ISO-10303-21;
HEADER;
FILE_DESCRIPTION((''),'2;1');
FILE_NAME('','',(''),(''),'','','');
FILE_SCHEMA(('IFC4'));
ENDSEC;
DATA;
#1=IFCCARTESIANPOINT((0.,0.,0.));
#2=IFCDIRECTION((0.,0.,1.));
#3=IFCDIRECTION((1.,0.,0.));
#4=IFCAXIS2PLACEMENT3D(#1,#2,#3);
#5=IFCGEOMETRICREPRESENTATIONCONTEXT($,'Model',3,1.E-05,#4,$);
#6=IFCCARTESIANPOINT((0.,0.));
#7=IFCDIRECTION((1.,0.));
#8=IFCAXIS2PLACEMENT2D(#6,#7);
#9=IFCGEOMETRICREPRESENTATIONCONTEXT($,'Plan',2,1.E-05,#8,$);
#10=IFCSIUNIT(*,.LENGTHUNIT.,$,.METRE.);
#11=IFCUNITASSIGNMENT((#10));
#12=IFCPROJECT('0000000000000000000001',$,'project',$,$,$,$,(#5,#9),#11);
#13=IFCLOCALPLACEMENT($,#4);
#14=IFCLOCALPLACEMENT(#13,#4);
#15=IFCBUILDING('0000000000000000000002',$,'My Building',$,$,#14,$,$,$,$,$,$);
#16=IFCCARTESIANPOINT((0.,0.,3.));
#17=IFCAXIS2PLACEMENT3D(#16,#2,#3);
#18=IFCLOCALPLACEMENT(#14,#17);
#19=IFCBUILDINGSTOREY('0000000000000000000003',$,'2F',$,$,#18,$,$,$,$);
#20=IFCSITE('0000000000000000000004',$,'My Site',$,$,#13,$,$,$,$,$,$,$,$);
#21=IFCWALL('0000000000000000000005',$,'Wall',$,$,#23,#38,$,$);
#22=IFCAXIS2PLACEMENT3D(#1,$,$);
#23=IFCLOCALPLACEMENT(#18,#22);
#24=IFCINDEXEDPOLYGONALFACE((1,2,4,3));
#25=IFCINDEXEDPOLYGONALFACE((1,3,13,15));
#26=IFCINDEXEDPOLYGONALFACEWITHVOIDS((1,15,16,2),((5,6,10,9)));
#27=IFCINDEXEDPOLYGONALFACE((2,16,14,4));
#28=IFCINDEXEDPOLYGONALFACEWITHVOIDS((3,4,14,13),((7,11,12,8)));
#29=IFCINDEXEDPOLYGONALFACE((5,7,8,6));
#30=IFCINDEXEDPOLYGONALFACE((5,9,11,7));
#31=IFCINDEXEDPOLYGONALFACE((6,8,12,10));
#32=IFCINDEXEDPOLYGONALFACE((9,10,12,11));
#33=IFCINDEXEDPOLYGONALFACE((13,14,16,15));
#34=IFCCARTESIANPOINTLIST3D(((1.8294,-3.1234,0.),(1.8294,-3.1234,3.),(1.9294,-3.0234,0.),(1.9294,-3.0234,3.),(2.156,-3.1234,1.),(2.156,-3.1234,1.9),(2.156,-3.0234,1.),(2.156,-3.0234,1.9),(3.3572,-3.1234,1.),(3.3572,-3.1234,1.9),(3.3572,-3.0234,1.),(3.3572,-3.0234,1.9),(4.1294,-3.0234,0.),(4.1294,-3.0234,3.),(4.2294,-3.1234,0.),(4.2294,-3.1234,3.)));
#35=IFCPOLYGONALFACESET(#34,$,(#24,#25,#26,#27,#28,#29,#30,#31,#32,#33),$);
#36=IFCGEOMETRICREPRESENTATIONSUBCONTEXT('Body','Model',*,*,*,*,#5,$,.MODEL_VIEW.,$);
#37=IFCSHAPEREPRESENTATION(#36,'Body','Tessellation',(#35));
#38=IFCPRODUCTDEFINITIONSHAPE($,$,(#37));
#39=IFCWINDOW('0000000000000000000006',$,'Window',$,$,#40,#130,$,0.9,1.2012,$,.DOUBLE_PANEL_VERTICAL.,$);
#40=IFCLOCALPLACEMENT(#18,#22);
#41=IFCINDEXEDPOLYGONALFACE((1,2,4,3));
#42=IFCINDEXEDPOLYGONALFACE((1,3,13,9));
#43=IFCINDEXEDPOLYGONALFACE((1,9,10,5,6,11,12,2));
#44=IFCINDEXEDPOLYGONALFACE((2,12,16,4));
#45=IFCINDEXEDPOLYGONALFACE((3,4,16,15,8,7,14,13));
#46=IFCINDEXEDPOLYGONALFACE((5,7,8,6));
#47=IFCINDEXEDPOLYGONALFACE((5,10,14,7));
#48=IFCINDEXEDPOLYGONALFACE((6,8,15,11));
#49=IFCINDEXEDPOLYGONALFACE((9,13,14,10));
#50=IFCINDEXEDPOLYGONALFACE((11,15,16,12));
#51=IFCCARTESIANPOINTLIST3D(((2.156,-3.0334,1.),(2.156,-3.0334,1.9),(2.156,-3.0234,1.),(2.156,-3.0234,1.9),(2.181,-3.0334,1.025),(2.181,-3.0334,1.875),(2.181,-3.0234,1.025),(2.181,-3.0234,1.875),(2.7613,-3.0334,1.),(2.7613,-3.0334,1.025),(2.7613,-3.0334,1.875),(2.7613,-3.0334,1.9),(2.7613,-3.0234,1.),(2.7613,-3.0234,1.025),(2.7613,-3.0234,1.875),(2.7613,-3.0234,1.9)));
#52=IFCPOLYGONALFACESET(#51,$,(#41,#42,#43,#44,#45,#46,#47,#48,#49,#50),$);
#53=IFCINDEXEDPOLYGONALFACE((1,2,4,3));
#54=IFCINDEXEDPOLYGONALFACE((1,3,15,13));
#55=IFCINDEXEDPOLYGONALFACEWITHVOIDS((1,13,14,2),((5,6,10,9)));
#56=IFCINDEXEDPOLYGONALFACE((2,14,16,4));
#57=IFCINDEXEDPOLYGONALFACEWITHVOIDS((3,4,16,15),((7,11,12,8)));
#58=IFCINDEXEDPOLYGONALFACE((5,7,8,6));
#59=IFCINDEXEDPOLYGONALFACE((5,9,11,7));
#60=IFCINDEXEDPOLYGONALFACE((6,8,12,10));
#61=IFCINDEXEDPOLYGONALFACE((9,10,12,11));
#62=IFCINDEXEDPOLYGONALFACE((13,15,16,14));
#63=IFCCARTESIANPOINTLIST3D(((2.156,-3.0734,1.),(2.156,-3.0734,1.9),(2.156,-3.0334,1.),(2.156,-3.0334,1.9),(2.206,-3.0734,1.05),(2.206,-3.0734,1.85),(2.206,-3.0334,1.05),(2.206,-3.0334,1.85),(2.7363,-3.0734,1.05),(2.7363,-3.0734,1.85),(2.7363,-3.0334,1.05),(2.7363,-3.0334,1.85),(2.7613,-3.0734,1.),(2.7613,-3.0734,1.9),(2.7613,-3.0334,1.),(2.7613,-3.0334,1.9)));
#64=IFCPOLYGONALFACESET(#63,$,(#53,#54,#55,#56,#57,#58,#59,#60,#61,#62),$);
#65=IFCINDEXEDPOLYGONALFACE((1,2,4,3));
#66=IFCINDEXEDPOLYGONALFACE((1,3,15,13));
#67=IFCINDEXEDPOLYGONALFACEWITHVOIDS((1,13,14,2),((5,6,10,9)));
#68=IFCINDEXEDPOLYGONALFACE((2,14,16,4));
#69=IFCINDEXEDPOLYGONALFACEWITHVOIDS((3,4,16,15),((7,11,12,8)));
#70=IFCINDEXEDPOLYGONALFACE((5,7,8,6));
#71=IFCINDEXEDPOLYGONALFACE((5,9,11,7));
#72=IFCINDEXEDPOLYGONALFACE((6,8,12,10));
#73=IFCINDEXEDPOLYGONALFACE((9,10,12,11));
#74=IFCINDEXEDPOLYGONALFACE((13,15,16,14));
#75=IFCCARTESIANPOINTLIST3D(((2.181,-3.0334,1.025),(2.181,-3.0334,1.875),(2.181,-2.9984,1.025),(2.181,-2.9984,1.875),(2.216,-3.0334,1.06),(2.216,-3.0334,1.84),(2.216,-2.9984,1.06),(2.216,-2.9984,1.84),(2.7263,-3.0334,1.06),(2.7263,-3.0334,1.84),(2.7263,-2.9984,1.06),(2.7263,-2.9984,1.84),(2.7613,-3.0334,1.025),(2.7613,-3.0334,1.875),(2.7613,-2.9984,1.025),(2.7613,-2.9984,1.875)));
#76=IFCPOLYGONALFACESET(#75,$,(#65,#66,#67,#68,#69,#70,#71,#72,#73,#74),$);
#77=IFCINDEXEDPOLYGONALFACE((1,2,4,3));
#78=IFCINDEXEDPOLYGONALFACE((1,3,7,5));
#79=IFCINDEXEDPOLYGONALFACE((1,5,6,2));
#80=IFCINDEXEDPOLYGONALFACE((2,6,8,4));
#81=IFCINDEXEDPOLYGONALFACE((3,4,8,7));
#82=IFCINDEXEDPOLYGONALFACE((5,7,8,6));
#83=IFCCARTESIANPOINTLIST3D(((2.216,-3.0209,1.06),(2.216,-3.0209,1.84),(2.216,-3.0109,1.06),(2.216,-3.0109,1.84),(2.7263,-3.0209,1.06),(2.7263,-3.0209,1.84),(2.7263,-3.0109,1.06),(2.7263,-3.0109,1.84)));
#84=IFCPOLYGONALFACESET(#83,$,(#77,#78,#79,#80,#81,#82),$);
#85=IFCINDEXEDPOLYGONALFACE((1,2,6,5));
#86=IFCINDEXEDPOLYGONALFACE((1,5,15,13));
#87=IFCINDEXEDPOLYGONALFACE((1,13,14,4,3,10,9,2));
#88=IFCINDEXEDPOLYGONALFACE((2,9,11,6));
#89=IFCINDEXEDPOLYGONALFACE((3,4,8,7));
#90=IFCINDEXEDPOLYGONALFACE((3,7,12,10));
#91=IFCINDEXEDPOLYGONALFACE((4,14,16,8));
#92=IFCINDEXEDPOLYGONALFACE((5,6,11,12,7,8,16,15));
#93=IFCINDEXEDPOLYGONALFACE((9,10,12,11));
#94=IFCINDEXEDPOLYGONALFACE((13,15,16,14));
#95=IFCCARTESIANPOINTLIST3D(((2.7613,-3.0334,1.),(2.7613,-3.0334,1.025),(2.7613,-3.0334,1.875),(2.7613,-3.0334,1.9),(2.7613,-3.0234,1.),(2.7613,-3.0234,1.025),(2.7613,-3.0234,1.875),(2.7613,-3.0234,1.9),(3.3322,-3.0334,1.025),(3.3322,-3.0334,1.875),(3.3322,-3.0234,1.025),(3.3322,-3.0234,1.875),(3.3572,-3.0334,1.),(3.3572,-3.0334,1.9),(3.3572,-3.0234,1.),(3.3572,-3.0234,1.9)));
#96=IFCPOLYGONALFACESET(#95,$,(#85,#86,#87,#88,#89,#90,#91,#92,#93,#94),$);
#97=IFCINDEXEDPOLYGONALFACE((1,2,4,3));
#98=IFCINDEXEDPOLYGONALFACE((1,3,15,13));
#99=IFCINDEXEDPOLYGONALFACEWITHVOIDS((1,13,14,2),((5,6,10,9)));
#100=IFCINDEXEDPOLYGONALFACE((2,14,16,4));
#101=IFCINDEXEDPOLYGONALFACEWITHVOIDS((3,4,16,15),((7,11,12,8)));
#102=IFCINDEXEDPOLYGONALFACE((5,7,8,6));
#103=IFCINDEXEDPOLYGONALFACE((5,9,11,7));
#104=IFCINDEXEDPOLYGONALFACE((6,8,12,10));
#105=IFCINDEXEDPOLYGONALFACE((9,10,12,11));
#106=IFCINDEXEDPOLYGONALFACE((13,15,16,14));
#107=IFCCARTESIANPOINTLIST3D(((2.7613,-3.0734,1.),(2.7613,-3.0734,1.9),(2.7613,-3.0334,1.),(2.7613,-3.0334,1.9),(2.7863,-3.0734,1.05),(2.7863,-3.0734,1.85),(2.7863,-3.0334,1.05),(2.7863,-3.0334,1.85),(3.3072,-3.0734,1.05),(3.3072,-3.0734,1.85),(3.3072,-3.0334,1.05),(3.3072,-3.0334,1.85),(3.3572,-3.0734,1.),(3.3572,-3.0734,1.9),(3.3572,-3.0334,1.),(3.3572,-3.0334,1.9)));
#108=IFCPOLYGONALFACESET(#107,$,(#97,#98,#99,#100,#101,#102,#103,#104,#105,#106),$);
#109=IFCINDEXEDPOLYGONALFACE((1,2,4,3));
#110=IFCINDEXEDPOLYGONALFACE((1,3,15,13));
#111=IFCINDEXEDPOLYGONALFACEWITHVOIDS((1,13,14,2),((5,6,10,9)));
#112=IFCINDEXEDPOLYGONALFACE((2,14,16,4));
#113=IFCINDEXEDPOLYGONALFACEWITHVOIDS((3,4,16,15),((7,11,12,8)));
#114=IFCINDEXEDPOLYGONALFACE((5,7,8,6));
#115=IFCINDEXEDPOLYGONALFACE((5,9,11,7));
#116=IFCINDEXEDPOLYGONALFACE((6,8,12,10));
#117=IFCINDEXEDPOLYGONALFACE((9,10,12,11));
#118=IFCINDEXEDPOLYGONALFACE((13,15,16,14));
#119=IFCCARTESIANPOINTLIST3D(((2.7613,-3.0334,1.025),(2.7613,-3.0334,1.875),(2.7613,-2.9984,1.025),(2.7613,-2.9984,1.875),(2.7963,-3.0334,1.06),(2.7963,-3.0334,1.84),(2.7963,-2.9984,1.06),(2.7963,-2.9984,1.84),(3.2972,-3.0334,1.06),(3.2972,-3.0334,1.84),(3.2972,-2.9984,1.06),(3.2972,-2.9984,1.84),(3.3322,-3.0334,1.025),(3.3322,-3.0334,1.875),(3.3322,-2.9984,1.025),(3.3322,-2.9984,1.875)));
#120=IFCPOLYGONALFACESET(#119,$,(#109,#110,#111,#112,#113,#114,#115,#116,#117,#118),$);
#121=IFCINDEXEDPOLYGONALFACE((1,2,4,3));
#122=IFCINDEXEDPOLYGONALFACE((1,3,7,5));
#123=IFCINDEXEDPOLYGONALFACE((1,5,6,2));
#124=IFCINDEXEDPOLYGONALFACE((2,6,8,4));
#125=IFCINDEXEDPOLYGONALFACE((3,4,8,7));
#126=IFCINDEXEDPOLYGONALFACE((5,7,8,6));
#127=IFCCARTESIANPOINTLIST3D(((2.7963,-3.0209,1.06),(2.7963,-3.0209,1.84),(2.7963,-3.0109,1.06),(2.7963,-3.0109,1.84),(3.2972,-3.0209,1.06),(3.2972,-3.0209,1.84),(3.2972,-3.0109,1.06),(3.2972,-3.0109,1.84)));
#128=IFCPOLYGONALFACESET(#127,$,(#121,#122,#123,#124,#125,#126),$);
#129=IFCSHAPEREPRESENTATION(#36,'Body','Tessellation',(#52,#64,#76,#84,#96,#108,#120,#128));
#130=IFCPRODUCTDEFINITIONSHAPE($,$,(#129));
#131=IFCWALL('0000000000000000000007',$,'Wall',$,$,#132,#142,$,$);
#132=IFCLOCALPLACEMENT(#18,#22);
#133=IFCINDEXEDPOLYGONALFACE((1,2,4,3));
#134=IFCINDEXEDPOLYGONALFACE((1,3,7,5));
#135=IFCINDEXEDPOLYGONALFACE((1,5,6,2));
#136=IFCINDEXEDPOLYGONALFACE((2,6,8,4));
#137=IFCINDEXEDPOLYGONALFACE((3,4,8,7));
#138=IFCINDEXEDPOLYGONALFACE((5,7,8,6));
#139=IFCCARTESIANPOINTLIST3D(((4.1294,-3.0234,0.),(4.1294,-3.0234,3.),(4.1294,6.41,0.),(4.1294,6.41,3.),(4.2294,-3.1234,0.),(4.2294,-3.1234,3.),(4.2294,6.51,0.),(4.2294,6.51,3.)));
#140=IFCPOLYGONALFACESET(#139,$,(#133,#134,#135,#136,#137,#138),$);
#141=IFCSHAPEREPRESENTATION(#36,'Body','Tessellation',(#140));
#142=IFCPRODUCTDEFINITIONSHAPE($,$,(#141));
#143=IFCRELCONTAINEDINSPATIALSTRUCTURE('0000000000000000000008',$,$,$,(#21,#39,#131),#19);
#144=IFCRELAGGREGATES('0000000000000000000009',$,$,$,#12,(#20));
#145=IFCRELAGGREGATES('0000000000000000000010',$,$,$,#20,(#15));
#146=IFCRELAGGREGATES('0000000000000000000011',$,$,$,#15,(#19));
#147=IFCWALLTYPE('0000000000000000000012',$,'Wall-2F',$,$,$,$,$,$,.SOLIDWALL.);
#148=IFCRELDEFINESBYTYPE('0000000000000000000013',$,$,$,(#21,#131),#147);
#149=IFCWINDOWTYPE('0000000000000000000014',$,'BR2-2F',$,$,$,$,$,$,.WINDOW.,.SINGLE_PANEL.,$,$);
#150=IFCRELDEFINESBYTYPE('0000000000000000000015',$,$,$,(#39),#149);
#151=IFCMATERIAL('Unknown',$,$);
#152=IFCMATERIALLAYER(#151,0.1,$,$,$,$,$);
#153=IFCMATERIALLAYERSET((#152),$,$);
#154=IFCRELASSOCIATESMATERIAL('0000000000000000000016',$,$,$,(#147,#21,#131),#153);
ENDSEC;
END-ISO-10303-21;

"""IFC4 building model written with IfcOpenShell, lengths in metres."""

from ifc_helpers import new_model, entity, si_unit, frame, origin_with_axes, origin_2d_with_axis, place, context, subcontext, project, spatial, line, indexed_curve, outline, extrude, shape, source, transform, mapped, material, layer, layer_set, layer_usage, type_object, type_shapes, element, fill, save


model = new_model("IFC4")

# Units and contexts
model_context = context("Model", 3, precision=1e-05, world=origin_with_axes())
plan_context = context("Plan", 2, precision=1e-05, world=origin_2d_with_axis())
body_context_1 = subcontext(model_context, "Body", "Model", "MODEL_VIEW")
body_context_2 = subcontext(plan_context, "Body", "Plan", "PLAN_VIEW")
ifc_project = project(units=[si_unit("LENGTHUNIT", "METRE")], contexts=[model_context, plan_context])

# Site, building, storey
site_placement = place(None, origin_with_axes())
site = spatial("IfcSite", under=ifc_project, at=site_placement, Name="My Site")
building_placement = place(site_placement, origin_with_axes())
building = spatial("IfcBuilding", under=site, at=building_placement, Name="My Building")
storey_placement = place(building_placement, frame((0.0, 0.0, 3.0), z_axis=(0.0, 0.0, 1.0), x_axis=(1.0, 0.0, 0.0)))
storey = spatial("IfcBuildingStorey", under=building, at=storey_placement, Name="2F")

# Shared definitions
ifc_material = material(Name="Unknown")
ifc_layer = layer(ifc_material, 0.1)
ifc_layer_set = layer_set([ifc_layer])
wall_type = type_object("IfcWallType", Name="Wall-2F", PredefinedType="SOLIDWALL", material=ifc_layer_set)

# Wall, opening, window
ifc_layer_usage_1 = layer_usage(ifc_layer_set, "AXIS2", "POSITIVE", 0.0)
wall_1_placement = place(storey_placement, frame((1.8294, -3.1234, 0.0), z_axis=(0.0, 0.0, 1.0), x_axis=(1.0, 0.0, 0.0)))
wall_1 = element("IfcWall", 1, at=wall_1_placement, inside=storey, type_object=wall_type, material=ifc_layer_usage_1, Name="Wall", context=body_context_1, shape_type="SweptSolid", body=[
    extrude(outline(indexed_curve([(0.0, 0.0), (0.1, 0.1), (2.3, 0.1), (2.4, 0.0)], segments=[line(1, 2, 3, 4, 1)])), origin_with_axes(), (0.0, 0.0, 1.0), 3.0),
])
shared_shape_1 = source(origin_with_axes(), body_context_1, "Body", "SweptSolid", [
    extrude(outline(indexed_curve([(0.0, 0.0), (1.2012, 0.0), (1.2012, 0.9), (0.0, 0.9)], segments=[line(1, 2, 3, 4, 1)])), frame((0.0, -0.6, 0.0), z_axis=(0.0, -1.0, 0.0), x_axis=(1.0, 0.0, 0.0)), (0.0, 0.0, -1.0), 1.2),
])
opening_1_placement = place(wall_1_placement, frame((0.3266, 0.0, 1.0), z_axis=(0.0, 0.0, 1.0), x_axis=(1.0, 0.0, 0.0)))
opening_1 = element("IfcOpeningElement", 2, at=opening_1_placement, cuts=wall_1, PredefinedType="OPENING", context=body_context_1, shape_type="MappedRepresentation", body=[
    mapped(shared_shape_1, transform((0.0, 0.0, 0.0), x_axis=(1.0, 0.0, 0.0), y_axis=(0.0, 1.0, 0.0), z_axis=(0.0, 0.0, 1.0), scale=1.0)),
])
window_type_1 = type_object("IfcWindowType", Name="BR2-2F", PartitioningType="SINGLE_PANEL", PredefinedType="WINDOW")
shared_shape_2 = source(origin_with_axes(), body_context_1, "Body", "SweptSolid", [
    extrude(outline(indexed_curve([(0.6053, 0.0), (0.0, 0.0), (0.0, 0.9), (0.6053, 0.9), (0.6053, 0.875), (0.025, 0.875), (0.025, 0.025), (0.6053, 0.025)], segments=[line(1, 2, 3, 4, 5, 6, 7, 8, 1)])), frame((0.0, 0.09, 0.0), z_axis=(0.0, -1.0, 0.0), x_axis=(1.0, 0.0, 0.0)), (0.0, 0.0, -1.0), 0.01),
    extrude(outline(indexed_curve([(0.0, 0.0), (0.6053, 0.0), (0.6053, 0.9), (0.0, 0.9)], segments=[line(1, 2, 3, 4, 1)]), holes=[indexed_curve([(0.05, 0.05), (0.5803, 0.05), (0.5803, 0.85), (0.05, 0.85)], segments=[line(1, 2, 3, 4, 1)])]), frame((0.0, 0.05, 0.0), z_axis=(0.0, -1.0, 0.0), x_axis=(1.0, 0.0, 0.0)), (0.0, 0.0, -1.0), 0.04),
    extrude(outline(indexed_curve([(0.0, 0.0), (0.5803, 0.0), (0.5803, 0.85), (0.0, 0.85)], segments=[line(1, 2, 3, 4, 1)]), holes=[indexed_curve([(0.035, 0.035), (0.5453, 0.035), (0.5453, 0.815), (0.035, 0.815)], segments=[line(1, 2, 3, 4, 1)])]), frame((0.025, 0.09, 0.025), z_axis=(0.0, -1.0, 0.0), x_axis=(1.0, 0.0, 0.0)), (0.0, 0.0, -1.0), 0.035),
    extrude(outline(indexed_curve([(0.035, 0.035), (0.5453, 0.035), (0.5453, 0.815), (0.035, 0.815)], segments=[line(1, 2, 3, 4, 1)])), frame((0.025, 0.1025, 0.025), z_axis=(0.0, -1.0, 0.0), x_axis=(1.0, 0.0, 0.0)), (0.0, 0.0, -1.0), 0.01),
    extrude(outline(indexed_curve([(0.0, 0.9), (0.5958, 0.9), (0.5958, 0.0), (0.0, 0.0), (0.0, 0.025), (0.5708, 0.025), (0.5708, 0.875), (0.0, 0.875)], segments=[line(1, 2, 3, 4, 5, 6, 7, 8, 1)])), frame((0.6053, 0.09, 0.0), z_axis=(0.0, -1.0, 0.0), x_axis=(1.0, 0.0, 0.0)), (0.0, 0.0, -1.0), 0.01),
    extrude(outline(indexed_curve([(0.0, 0.0), (0.5958, 0.0), (0.5958, 0.9), (0.0, 0.9)], segments=[line(1, 2, 3, 4, 1)]), holes=[indexed_curve([(0.025, 0.05), (0.5458, 0.05), (0.5458, 0.85), (0.025, 0.85)], segments=[line(1, 2, 3, 4, 1)])]), frame((0.6053, 0.05, 0.0), z_axis=(0.0, -1.0, 0.0), x_axis=(1.0, 0.0, 0.0)), (0.0, 0.0, -1.0), 0.04),
    extrude(outline(indexed_curve([(0.0, 0.0), (0.5708, 0.0), (0.5708, 0.85), (0.0, 0.85)], segments=[line(1, 2, 3, 4, 1)]), holes=[indexed_curve([(0.035, 0.035), (0.5358, 0.035), (0.5358, 0.815), (0.035, 0.815)], segments=[line(1, 2, 3, 4, 1)])]), frame((0.6053, 0.09, 0.025), z_axis=(0.0, -1.0, 0.0), x_axis=(1.0, 0.0, 0.0)), (0.0, 0.0, -1.0), 0.035),
    extrude(outline(indexed_curve([(0.035, 0.035), (0.5358, 0.035), (0.5358, 0.815), (0.035, 0.815)], segments=[line(1, 2, 3, 4, 1)])), frame((0.6053, 0.1025, 0.025), z_axis=(0.0, -1.0, 0.0), x_axis=(1.0, 0.0, 0.0)), (0.0, 0.0, -1.0), 0.01),
])
shared_shape_3 = source(origin_with_axes(), body_context_2, "Body", "Curve2D", [
    entity("IfcIndexedPolyCurve", entity("IfcCartesianPointList2D", [[0.05, 0.05], [0.5803, 0.05]])),
    entity("IfcIndexedPolyCurve", entity("IfcCartesianPointList2D", [[0.0, 0.1], [0.025, 0.1], [0.025, 0.09], [0.05, 0.09], [0.05, 0.05], [0.0, 0.05]]), [entity("IfcLineIndex", [1, 2, 3, 4, 5, 6, 1])]),
    entity("IfcIndexedPolyCurve", entity("IfcCartesianPointList2D", [[0.6053, 0.1], [0.6053, 0.1], [0.6053, 0.09], [0.5803, 0.09], [0.5803, 0.05], [0.6053, 0.05]])),
    entity("IfcIndexedPolyCurve", entity("IfcCartesianPointList2D", [[0.025, 0.09], [0.06, 0.09], [0.06, 0.125], [0.025, 0.125]]), [entity("IfcLineIndex", [1, 2, 3, 4, 1])]),
    entity("IfcIndexedPolyCurve", entity("IfcCartesianPointList2D", [[0.6053, 0.09], [0.5703, 0.09], [0.5703, 0.125], [0.6053, 0.125]]), [entity("IfcLineIndex", [1, 2, 3, 4, 1])]),
    entity("IfcIndexedPolyCurve", entity("IfcCartesianPointList2D", [[0.06, 0.09], [0.5703, 0.09]])),
    entity("IfcIndexedPolyCurve", entity("IfcCartesianPointList2D", [[0.06, 0.125], [0.5703, 0.125]])),
    entity("IfcIndexedPolyCurve", entity("IfcCartesianPointList2D", [[0.06, 0.1075], [0.5703, 0.1075]])),
    entity("IfcIndexedPolyCurve", entity("IfcCartesianPointList2D", [[0.6303, 0.05], [1.1512, 0.05]])),
    entity("IfcIndexedPolyCurve", entity("IfcCartesianPointList2D", [[0.6053, 0.1], [0.6053, 0.1], [0.6053, 0.09], [0.6303, 0.09], [0.6303, 0.05], [0.6053, 0.05]])),
    entity("IfcIndexedPolyCurve", entity("IfcCartesianPointList2D", [[1.2012, 0.1], [1.1762, 0.1], [1.1762, 0.09], [1.1512, 0.09], [1.1512, 0.05], [1.2012, 0.05]]), [entity("IfcLineIndex", [1, 2, 3, 4, 5, 6, 1])]),
    entity("IfcIndexedPolyCurve", entity("IfcCartesianPointList2D", [[0.6053, 0.09], [0.6403, 0.09], [0.6403, 0.125], [0.6053, 0.125]]), [entity("IfcLineIndex", [1, 2, 3, 4, 1])]),
    entity("IfcIndexedPolyCurve", entity("IfcCartesianPointList2D", [[1.1762, 0.09], [1.1412, 0.09], [1.1412, 0.125], [1.1762, 0.125]]), [entity("IfcLineIndex", [1, 2, 3, 4, 1])]),
    entity("IfcIndexedPolyCurve", entity("IfcCartesianPointList2D", [[0.6403, 0.09], [1.1412, 0.09]])),
    entity("IfcIndexedPolyCurve", entity("IfcCartesianPointList2D", [[0.6403, 0.125], [1.1412, 0.125]])),
    entity("IfcIndexedPolyCurve", entity("IfcCartesianPointList2D", [[0.6403, 0.1075], [1.1412, 0.1075]])),
])
type_shapes(window_type_1, [shared_shape_2, shared_shape_3])
window_1_placement = place(opening_1_placement, origin_with_axes())
window_1 = element("IfcWindow", 3, at=window_1_placement, inside=storey, type_object=window_type_1, Name="Window", OverallHeight=0.9, OverallWidth=1.2012, PartitioningType="DOUBLE_PANEL_VERTICAL", shapes=[
    shape(body_context_1, "Body", "MappedRepresentation", [mapped(shared_shape_2, transform((0.0, 0.0, 0.0), x_axis=(1.0, 0.0, 0.0), y_axis=(0.0, 1.0, 0.0), z_axis=(0.0, 0.0, 1.0), scale=1.0))]),
    shape(body_context_2, "Body", "MappedRepresentation", [mapped(shared_shape_3, transform((0.0, 0.0, 0.0), x_axis=(1.0, 0.0, 0.0), y_axis=(0.0, 1.0, 0.0), z_axis=(0.0, 0.0, 1.0), scale=1.0))]),
])
fill(opening_1, window_1)

# Wall
ifc_layer_usage_2 = layer_usage(ifc_layer_set, "AXIS2", "POSITIVE", 0.0)
wall_2_placement = place(storey_placement, frame((4.2294, -3.1234, 0.0), z_axis=(0.0, 0.0, 1.0), x_axis=(0.0, 1.0, 0.0)))
element("IfcWall", 4, at=wall_2_placement, inside=storey, type_object=wall_type, material=ifc_layer_usage_2, Name="Wall", context=body_context_1, shape_type="SweptSolid", body=[
    extrude(outline(indexed_curve([(0.0, 0.0), (0.1, 0.1), (9.5334, 0.1), (9.6334, 0.0)], segments=[line(1, 2, 3, 4, 1)])), origin_with_axes(), (0.0, 0.0, 1.0), 3.0),
])

save(model, "model.ifc")
